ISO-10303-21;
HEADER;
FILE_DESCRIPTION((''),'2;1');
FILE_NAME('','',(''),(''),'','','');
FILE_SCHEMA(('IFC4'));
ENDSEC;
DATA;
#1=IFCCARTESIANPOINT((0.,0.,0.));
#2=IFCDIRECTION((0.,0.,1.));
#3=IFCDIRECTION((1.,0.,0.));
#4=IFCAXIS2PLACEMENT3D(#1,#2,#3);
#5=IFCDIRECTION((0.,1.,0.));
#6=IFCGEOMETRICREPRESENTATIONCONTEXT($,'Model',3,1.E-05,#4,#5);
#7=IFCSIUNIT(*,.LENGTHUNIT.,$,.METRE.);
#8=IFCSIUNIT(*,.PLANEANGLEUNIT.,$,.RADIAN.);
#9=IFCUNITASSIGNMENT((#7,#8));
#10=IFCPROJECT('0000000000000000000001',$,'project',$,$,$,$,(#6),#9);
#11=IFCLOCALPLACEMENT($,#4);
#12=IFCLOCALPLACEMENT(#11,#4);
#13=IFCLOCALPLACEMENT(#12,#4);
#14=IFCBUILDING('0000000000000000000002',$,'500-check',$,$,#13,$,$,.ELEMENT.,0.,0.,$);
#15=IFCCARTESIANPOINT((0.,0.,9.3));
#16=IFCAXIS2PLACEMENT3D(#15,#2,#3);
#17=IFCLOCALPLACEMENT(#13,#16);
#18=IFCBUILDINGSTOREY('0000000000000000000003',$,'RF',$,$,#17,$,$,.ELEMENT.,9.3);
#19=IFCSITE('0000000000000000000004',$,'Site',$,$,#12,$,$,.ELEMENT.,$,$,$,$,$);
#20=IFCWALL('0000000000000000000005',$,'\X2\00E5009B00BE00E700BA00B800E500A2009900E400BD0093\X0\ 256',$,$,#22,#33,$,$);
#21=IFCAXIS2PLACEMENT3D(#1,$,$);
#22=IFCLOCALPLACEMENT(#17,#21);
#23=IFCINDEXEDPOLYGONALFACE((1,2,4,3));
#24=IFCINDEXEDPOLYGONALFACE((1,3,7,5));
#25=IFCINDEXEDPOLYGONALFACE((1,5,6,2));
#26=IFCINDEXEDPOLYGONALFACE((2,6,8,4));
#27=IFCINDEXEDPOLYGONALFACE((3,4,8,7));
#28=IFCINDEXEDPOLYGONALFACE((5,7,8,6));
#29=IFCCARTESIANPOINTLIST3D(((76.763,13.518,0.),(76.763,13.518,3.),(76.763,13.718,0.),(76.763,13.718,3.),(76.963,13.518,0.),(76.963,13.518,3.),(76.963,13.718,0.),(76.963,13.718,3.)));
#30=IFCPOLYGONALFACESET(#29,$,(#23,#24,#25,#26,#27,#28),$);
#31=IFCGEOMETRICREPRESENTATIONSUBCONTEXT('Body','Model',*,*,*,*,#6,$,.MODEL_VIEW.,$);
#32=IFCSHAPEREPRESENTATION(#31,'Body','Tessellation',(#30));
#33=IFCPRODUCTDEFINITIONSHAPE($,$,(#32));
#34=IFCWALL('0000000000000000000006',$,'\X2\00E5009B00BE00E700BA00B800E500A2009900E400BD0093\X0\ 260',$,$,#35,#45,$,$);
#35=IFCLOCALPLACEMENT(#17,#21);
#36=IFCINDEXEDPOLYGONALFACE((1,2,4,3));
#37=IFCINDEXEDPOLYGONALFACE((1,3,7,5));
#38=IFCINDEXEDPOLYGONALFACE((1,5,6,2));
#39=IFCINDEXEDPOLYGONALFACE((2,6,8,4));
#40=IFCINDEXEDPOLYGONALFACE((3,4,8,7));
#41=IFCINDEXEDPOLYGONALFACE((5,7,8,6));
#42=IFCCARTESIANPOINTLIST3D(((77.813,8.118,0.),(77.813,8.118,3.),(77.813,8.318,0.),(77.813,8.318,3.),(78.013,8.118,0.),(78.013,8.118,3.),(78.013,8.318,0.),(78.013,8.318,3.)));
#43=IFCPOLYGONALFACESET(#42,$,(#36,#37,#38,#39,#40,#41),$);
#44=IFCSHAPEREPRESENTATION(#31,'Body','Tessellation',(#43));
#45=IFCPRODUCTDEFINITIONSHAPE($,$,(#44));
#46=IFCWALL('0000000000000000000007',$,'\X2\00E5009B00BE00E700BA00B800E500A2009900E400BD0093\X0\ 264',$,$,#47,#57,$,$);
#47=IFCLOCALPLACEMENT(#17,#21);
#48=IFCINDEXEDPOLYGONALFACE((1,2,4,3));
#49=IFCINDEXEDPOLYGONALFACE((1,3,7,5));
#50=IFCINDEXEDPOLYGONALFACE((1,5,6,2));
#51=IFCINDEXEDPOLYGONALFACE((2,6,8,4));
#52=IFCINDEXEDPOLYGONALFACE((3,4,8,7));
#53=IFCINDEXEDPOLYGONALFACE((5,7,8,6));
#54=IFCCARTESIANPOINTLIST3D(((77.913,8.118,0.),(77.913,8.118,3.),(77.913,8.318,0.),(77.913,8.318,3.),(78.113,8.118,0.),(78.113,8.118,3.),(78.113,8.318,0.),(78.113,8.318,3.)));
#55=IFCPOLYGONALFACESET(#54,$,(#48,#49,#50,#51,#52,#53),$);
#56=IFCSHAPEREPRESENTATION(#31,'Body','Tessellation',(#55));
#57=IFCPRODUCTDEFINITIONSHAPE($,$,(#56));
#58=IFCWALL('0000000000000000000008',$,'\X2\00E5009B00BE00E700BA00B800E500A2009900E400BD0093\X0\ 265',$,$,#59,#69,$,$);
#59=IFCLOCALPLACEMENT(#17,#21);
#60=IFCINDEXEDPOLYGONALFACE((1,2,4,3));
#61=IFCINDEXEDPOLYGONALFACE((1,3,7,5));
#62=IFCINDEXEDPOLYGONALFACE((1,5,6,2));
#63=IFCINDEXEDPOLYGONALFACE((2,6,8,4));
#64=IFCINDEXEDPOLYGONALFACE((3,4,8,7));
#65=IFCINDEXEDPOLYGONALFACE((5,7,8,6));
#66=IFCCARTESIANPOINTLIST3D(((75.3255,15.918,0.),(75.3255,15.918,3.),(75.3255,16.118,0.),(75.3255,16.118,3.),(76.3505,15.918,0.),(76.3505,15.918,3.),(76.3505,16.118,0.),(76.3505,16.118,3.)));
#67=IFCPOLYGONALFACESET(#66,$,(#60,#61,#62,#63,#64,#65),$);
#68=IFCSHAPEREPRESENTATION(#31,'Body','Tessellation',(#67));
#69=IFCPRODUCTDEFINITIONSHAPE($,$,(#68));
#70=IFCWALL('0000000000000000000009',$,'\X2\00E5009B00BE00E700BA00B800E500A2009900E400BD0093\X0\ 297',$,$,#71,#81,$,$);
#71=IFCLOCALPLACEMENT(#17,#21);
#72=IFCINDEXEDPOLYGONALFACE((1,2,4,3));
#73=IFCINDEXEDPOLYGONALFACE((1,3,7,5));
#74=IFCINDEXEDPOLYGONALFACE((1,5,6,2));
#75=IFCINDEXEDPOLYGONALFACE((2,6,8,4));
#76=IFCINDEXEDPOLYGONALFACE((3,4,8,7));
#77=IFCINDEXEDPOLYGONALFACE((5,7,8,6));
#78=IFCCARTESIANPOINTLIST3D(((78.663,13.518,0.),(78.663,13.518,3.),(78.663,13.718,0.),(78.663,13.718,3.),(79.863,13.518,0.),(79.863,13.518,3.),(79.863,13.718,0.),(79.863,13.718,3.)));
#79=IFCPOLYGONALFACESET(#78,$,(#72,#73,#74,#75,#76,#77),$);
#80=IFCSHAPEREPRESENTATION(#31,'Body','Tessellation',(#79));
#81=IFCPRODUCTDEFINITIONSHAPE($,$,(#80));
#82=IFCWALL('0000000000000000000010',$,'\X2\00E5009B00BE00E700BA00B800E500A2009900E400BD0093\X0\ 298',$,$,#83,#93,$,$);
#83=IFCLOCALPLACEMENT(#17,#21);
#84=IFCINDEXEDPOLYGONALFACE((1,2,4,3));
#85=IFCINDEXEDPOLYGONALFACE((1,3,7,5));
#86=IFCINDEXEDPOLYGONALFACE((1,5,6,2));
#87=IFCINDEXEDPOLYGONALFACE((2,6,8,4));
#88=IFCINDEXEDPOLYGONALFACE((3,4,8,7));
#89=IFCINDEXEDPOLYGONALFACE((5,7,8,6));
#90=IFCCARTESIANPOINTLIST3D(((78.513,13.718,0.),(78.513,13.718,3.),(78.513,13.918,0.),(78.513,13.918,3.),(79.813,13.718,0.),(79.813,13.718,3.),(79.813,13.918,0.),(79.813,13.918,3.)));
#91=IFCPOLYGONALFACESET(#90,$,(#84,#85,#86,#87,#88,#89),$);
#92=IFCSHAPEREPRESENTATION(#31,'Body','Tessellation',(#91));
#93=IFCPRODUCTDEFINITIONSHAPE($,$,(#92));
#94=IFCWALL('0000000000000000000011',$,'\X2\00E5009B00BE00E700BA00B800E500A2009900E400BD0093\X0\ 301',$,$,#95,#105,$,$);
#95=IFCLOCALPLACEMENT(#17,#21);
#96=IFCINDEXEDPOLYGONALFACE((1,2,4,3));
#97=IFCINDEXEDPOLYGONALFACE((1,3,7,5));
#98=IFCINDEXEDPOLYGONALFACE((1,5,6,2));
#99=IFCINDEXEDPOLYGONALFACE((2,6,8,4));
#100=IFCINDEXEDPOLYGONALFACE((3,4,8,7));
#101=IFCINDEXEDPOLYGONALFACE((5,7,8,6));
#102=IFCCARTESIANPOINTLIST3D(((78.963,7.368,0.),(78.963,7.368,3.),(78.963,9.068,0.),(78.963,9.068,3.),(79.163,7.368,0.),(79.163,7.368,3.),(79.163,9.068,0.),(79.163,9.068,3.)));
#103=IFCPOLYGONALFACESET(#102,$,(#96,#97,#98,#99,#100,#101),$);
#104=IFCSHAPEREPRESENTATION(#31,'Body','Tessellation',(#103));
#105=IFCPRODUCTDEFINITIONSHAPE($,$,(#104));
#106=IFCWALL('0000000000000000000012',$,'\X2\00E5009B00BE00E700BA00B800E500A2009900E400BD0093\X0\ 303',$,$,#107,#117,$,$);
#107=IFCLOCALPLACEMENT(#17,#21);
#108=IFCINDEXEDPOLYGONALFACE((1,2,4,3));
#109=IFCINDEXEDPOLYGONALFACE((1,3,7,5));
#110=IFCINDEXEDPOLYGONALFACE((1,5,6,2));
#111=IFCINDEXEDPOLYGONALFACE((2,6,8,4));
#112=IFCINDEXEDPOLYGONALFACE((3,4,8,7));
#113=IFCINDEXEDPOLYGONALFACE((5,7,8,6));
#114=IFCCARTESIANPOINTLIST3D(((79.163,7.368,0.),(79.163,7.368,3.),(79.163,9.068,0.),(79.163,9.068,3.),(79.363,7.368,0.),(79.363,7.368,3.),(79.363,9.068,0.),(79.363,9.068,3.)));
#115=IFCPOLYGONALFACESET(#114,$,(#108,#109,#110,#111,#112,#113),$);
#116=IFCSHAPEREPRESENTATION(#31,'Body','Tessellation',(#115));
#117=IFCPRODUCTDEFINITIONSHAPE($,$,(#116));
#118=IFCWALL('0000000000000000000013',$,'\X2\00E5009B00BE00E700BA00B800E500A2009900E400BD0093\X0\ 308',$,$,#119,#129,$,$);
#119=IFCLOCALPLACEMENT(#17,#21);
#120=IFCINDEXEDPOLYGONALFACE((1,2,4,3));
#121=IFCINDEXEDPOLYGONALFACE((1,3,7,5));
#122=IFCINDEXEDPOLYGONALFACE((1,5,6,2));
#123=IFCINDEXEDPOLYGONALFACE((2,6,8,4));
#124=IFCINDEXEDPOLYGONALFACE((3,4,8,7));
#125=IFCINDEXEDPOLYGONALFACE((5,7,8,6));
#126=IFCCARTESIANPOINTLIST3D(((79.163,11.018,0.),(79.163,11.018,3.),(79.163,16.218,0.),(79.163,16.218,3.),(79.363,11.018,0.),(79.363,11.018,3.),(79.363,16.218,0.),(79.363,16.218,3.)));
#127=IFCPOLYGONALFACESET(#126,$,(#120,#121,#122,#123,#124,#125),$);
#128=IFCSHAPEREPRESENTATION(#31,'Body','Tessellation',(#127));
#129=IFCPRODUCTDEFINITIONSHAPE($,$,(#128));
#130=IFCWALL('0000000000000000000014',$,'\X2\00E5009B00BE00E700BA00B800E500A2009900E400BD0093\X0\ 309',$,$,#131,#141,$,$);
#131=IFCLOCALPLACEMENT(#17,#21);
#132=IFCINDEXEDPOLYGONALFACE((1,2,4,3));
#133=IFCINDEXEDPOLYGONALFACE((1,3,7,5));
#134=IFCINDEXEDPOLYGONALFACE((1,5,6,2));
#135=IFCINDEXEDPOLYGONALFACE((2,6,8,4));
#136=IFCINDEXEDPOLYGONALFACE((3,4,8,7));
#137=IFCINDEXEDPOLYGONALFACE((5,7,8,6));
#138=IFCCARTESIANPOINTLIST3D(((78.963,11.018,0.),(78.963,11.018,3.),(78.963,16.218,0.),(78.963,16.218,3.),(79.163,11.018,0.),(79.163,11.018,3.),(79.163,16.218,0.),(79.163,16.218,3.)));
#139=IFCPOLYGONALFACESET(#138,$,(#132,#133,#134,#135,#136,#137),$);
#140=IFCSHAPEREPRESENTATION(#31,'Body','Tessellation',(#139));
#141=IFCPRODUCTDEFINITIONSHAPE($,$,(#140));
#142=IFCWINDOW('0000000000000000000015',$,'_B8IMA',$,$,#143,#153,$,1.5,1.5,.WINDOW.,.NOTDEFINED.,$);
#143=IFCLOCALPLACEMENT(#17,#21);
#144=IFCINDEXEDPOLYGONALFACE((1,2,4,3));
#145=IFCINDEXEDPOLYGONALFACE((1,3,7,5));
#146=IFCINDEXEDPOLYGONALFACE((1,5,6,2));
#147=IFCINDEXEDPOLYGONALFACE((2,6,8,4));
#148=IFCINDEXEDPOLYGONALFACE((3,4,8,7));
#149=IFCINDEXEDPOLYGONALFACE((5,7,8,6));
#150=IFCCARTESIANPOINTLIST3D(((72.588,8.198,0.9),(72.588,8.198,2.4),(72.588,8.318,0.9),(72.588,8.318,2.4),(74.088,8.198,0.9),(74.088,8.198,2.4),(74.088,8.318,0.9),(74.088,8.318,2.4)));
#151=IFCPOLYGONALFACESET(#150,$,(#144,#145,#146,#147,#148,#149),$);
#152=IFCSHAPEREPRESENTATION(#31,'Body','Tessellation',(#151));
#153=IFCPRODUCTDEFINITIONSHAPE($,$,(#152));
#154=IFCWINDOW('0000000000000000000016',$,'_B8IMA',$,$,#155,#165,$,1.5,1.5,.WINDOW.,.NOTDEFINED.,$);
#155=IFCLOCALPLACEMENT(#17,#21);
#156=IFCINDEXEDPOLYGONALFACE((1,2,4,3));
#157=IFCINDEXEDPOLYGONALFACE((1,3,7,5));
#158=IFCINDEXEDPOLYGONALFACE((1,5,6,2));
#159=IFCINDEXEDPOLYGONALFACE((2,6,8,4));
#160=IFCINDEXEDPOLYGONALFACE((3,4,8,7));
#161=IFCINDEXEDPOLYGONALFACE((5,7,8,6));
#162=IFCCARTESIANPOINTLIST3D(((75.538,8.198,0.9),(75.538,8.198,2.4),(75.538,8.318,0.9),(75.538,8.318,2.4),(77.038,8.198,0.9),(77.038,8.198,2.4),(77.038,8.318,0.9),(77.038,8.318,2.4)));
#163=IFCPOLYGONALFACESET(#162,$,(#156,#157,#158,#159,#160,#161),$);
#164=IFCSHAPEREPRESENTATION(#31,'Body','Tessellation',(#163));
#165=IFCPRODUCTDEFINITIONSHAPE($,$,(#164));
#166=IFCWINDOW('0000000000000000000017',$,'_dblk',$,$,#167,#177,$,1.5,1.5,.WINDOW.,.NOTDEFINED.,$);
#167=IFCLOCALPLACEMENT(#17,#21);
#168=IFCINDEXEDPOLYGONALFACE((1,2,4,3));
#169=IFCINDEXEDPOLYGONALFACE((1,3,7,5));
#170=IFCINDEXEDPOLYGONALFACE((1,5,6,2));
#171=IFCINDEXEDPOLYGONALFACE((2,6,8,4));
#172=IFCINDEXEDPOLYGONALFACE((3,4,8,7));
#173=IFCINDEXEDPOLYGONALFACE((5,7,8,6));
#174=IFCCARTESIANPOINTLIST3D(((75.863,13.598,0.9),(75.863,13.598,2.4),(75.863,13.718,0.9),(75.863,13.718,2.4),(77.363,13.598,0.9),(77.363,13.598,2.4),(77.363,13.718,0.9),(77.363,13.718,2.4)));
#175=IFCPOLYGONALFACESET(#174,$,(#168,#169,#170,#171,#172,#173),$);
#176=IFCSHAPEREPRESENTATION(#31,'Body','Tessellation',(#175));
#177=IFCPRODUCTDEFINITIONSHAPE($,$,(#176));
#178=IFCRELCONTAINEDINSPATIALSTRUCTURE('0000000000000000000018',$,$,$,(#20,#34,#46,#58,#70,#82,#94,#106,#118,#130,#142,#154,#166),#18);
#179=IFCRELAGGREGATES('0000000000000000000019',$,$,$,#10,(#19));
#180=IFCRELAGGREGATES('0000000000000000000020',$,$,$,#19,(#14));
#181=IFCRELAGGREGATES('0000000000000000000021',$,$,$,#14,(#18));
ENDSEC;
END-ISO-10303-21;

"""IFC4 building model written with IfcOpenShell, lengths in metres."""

from ifc_helpers import new_model, si_unit, direction, frame, frame_2d, origin_with_axes, place, context, subcontext, project, spatial, rectangle, extrude, element, save


model = new_model("IFC4")

# Units and contexts
model_context = context("Model", 3, precision=1e-05, world=origin_with_axes(), true_north=direction((0.0, 1.0, 0.0)))
body_context = subcontext(model_context, "Body", "Model", "MODEL_VIEW")
ifc_project = project(units=[si_unit("LENGTHUNIT", "METRE"), si_unit("PLANEANGLEUNIT", "RADIAN")], contexts=[model_context])

# Site, building, storey
placement = place(None, origin_with_axes())
site_placement = place(placement, origin_with_axes())
site = spatial("IfcSite", under=ifc_project, at=site_placement, Name="Site", CompositionType="ELEMENT")
building_placement = place(site_placement, origin_with_axes())
building = spatial("IfcBuilding", under=site, at=building_placement, Name="500-check", CompositionType="ELEMENT", ElevationOfRefHeight=0.0, ElevationOfTerrain=0.0)
storey_placement = place(building_placement, frame((0.0, 0.0, 9.3), z_axis=(0.0, 0.0, 1.0), x_axis=(1.0, 0.0, 0.0)))
storey = spatial("IfcBuildingStorey", under=building, at=storey_placement, Name="RF", CompositionType="ELEMENT", Elevation=9.3)

# Walls
for number, where, z_axis, x_axis, name in (
    (1, (76.863, 13.618, 0.0), (0.0, 0.0, 1.0), (0.0, 1.0, 0.0), "å\u009b¾çº¸å¢\u0099ä½\u0093 256"),
    (2, (77.913, 8.218, 0.0), (0.0, 0.0, 1.0), (0.0, 1.0, 0.0), "å\u009b¾çº¸å¢\u0099ä½\u0093 260"),
    (3, (78.013, 8.218, 0.0), (0.0, 0.0, 1.0), (0.0, -1.0, 0.0), "å\u009b¾çº¸å¢\u0099ä½\u0093 264"),
):
    element("IfcWall", number, at=place(storey_placement, frame(where, z_axis=z_axis, x_axis=x_axis)), inside=storey, Name=name, context=body_context, shape_type="SweptSolid", body=[
        extrude(rectangle(XDim=0.2, YDim=0.2, at=frame_2d((0.0, 0.0), x_axis=(1.0, 0.0, 0.0))), frame((0.0, 0.0, 0.0), z_axis=(0.0, 0.0, 1.0)), (0.0, 0.0, 1.0), 3.0),
    ])
wall_1_placement = place(storey_placement, frame((75.838, 16.018, 0.0), z_axis=(0.0, 0.0, 1.0), x_axis=(1.0, 0.0, 0.0)))
element("IfcWall", 4, at=wall_1_placement, inside=storey, Name="å\u009b¾çº¸å¢\u0099ä½\u0093 265", context=body_context, shape_type="SweptSolid", body=[
    extrude(rectangle(XDim=1.025, YDim=0.2, at=frame_2d((0.0, 0.0), x_axis=(1.0, 0.0, 0.0))), frame((0.0, 0.0, 0.0), z_axis=(0.0, 0.0, 1.0)), (0.0, 0.0, 1.0), 3.0),
])
wall_2_placement = place(storey_placement, frame((79.263, 13.618, 0.0), z_axis=(0.0, 0.0, 1.0), x_axis=(1.0, 0.0, 0.0)))
element("IfcWall", 5, at=wall_2_placement, inside=storey, Name="å\u009b¾çº¸å¢\u0099ä½\u0093 297", context=body_context, shape_type="SweptSolid", body=[
    extrude(rectangle(XDim=1.2, YDim=0.2, at=frame_2d((0.0, 0.0), x_axis=(1.0, 0.0, 0.0))), frame((0.0, 0.0, 0.0), z_axis=(0.0, 0.0, 1.0)), (0.0, 0.0, 1.0), 3.0),
])
wall_3_placement = place(storey_placement, frame((79.163, 13.818, 0.0), z_axis=(0.0, 0.0, 1.0), x_axis=(1.0, 0.0, 0.0)))
element("IfcWall", 6, at=wall_3_placement, inside=storey, Name="å\u009b¾çº¸å¢\u0099ä½\u0093 298", context=body_context, shape_type="SweptSolid", body=[
    extrude(rectangle(XDim=1.3, YDim=0.2, at=frame_2d((0.0, 0.0), x_axis=(1.0, 0.0, 0.0))), frame((0.0, 0.0, 0.0), z_axis=(0.0, 0.0, 1.0)), (0.0, 0.0, 1.0), 3.0),
])
for number, where, z_axis, x_axis, name in (
    (7, (79.063, 8.218, 0.0), (0.0, 0.0, 1.0), (0.0, -1.0, 0.0), "å\u009b¾çº¸å¢\u0099ä½\u0093 301"),
    (8, (79.263, 8.218, 0.0), (0.0, 0.0, 1.0), (0.0, -1.0, 0.0), "å\u009b¾çº¸å¢\u0099ä½\u0093 303"),
):
    element("IfcWall", number, at=place(storey_placement, frame(where, z_axis=z_axis, x_axis=x_axis)), inside=storey, Name=name, context=body_context, shape_type="SweptSolid", body=[
        extrude(rectangle(XDim=1.7, YDim=0.2, at=frame_2d((0.0, 0.0), x_axis=(1.0, 0.0, 0.0))), frame((0.0, 0.0, 0.0), z_axis=(0.0, 0.0, 1.0)), (0.0, 0.0, 1.0), 3.0),
    ])
for number, where, z_axis, x_axis, name in (
    (9, (79.263, 13.618, 0.0), (0.0, 0.0, 1.0), (0.0, -1.0, 0.0), "å\u009b¾çº¸å¢\u0099ä½\u0093 308"),
    (10, (79.063, 13.618, 0.0), (0.0, 0.0, 1.0), (0.0, -1.0, 0.0), "å\u009b¾çº¸å¢\u0099ä½\u0093 309"),
):
    element("IfcWall", number, at=place(storey_placement, frame(where, z_axis=z_axis, x_axis=x_axis)), inside=storey, Name=name, context=body_context, shape_type="SweptSolid", body=[
        extrude(rectangle(XDim=5.2, YDim=0.2, at=frame_2d((0.0, 0.0), x_axis=(1.0, 0.0, 0.0))), frame((0.0, 0.0, 0.0), z_axis=(0.0, 0.0, 1.0)), (0.0, 0.0, 1.0), 3.0),
    ])

# Windows
for number, where, z_axis, x_axis, name in (
    (11, (73.338, 8.258, 0.9), (0.0, 0.0, 1.0), (1.0, 0.0, 0.0), "_B8IMA"),
    (12, (76.288, 8.258, 0.9), (0.0, 0.0, 1.0), (1.0, 0.0, 0.0), "_B8IMA"),
    (13, (76.613, 13.658, 0.9), (0.0, 0.0, 1.0), (1.0, 0.0, 0.0), "_dblk"),
):
    element("IfcWindow", number, at=place(storey_placement, frame(where, z_axis=z_axis, x_axis=x_axis)), inside=storey, Name=name, OverallHeight=1.5, OverallWidth=1.5, PartitioningType="NOTDEFINED", PredefinedType="WINDOW", context=body_context, shape_type="SweptSolid", body=[
        extrude(rectangle(XDim=1.5, YDim=0.12, at=frame_2d((0.0, 0.0), x_axis=(1.0, 0.0, 0.0))), frame((0.0, 0.0, 0.0), z_axis=(0.0, 0.0, 1.0)), (0.0, 0.0, 1.0), 1.5),
    ])

save(model, "model.ifc")
